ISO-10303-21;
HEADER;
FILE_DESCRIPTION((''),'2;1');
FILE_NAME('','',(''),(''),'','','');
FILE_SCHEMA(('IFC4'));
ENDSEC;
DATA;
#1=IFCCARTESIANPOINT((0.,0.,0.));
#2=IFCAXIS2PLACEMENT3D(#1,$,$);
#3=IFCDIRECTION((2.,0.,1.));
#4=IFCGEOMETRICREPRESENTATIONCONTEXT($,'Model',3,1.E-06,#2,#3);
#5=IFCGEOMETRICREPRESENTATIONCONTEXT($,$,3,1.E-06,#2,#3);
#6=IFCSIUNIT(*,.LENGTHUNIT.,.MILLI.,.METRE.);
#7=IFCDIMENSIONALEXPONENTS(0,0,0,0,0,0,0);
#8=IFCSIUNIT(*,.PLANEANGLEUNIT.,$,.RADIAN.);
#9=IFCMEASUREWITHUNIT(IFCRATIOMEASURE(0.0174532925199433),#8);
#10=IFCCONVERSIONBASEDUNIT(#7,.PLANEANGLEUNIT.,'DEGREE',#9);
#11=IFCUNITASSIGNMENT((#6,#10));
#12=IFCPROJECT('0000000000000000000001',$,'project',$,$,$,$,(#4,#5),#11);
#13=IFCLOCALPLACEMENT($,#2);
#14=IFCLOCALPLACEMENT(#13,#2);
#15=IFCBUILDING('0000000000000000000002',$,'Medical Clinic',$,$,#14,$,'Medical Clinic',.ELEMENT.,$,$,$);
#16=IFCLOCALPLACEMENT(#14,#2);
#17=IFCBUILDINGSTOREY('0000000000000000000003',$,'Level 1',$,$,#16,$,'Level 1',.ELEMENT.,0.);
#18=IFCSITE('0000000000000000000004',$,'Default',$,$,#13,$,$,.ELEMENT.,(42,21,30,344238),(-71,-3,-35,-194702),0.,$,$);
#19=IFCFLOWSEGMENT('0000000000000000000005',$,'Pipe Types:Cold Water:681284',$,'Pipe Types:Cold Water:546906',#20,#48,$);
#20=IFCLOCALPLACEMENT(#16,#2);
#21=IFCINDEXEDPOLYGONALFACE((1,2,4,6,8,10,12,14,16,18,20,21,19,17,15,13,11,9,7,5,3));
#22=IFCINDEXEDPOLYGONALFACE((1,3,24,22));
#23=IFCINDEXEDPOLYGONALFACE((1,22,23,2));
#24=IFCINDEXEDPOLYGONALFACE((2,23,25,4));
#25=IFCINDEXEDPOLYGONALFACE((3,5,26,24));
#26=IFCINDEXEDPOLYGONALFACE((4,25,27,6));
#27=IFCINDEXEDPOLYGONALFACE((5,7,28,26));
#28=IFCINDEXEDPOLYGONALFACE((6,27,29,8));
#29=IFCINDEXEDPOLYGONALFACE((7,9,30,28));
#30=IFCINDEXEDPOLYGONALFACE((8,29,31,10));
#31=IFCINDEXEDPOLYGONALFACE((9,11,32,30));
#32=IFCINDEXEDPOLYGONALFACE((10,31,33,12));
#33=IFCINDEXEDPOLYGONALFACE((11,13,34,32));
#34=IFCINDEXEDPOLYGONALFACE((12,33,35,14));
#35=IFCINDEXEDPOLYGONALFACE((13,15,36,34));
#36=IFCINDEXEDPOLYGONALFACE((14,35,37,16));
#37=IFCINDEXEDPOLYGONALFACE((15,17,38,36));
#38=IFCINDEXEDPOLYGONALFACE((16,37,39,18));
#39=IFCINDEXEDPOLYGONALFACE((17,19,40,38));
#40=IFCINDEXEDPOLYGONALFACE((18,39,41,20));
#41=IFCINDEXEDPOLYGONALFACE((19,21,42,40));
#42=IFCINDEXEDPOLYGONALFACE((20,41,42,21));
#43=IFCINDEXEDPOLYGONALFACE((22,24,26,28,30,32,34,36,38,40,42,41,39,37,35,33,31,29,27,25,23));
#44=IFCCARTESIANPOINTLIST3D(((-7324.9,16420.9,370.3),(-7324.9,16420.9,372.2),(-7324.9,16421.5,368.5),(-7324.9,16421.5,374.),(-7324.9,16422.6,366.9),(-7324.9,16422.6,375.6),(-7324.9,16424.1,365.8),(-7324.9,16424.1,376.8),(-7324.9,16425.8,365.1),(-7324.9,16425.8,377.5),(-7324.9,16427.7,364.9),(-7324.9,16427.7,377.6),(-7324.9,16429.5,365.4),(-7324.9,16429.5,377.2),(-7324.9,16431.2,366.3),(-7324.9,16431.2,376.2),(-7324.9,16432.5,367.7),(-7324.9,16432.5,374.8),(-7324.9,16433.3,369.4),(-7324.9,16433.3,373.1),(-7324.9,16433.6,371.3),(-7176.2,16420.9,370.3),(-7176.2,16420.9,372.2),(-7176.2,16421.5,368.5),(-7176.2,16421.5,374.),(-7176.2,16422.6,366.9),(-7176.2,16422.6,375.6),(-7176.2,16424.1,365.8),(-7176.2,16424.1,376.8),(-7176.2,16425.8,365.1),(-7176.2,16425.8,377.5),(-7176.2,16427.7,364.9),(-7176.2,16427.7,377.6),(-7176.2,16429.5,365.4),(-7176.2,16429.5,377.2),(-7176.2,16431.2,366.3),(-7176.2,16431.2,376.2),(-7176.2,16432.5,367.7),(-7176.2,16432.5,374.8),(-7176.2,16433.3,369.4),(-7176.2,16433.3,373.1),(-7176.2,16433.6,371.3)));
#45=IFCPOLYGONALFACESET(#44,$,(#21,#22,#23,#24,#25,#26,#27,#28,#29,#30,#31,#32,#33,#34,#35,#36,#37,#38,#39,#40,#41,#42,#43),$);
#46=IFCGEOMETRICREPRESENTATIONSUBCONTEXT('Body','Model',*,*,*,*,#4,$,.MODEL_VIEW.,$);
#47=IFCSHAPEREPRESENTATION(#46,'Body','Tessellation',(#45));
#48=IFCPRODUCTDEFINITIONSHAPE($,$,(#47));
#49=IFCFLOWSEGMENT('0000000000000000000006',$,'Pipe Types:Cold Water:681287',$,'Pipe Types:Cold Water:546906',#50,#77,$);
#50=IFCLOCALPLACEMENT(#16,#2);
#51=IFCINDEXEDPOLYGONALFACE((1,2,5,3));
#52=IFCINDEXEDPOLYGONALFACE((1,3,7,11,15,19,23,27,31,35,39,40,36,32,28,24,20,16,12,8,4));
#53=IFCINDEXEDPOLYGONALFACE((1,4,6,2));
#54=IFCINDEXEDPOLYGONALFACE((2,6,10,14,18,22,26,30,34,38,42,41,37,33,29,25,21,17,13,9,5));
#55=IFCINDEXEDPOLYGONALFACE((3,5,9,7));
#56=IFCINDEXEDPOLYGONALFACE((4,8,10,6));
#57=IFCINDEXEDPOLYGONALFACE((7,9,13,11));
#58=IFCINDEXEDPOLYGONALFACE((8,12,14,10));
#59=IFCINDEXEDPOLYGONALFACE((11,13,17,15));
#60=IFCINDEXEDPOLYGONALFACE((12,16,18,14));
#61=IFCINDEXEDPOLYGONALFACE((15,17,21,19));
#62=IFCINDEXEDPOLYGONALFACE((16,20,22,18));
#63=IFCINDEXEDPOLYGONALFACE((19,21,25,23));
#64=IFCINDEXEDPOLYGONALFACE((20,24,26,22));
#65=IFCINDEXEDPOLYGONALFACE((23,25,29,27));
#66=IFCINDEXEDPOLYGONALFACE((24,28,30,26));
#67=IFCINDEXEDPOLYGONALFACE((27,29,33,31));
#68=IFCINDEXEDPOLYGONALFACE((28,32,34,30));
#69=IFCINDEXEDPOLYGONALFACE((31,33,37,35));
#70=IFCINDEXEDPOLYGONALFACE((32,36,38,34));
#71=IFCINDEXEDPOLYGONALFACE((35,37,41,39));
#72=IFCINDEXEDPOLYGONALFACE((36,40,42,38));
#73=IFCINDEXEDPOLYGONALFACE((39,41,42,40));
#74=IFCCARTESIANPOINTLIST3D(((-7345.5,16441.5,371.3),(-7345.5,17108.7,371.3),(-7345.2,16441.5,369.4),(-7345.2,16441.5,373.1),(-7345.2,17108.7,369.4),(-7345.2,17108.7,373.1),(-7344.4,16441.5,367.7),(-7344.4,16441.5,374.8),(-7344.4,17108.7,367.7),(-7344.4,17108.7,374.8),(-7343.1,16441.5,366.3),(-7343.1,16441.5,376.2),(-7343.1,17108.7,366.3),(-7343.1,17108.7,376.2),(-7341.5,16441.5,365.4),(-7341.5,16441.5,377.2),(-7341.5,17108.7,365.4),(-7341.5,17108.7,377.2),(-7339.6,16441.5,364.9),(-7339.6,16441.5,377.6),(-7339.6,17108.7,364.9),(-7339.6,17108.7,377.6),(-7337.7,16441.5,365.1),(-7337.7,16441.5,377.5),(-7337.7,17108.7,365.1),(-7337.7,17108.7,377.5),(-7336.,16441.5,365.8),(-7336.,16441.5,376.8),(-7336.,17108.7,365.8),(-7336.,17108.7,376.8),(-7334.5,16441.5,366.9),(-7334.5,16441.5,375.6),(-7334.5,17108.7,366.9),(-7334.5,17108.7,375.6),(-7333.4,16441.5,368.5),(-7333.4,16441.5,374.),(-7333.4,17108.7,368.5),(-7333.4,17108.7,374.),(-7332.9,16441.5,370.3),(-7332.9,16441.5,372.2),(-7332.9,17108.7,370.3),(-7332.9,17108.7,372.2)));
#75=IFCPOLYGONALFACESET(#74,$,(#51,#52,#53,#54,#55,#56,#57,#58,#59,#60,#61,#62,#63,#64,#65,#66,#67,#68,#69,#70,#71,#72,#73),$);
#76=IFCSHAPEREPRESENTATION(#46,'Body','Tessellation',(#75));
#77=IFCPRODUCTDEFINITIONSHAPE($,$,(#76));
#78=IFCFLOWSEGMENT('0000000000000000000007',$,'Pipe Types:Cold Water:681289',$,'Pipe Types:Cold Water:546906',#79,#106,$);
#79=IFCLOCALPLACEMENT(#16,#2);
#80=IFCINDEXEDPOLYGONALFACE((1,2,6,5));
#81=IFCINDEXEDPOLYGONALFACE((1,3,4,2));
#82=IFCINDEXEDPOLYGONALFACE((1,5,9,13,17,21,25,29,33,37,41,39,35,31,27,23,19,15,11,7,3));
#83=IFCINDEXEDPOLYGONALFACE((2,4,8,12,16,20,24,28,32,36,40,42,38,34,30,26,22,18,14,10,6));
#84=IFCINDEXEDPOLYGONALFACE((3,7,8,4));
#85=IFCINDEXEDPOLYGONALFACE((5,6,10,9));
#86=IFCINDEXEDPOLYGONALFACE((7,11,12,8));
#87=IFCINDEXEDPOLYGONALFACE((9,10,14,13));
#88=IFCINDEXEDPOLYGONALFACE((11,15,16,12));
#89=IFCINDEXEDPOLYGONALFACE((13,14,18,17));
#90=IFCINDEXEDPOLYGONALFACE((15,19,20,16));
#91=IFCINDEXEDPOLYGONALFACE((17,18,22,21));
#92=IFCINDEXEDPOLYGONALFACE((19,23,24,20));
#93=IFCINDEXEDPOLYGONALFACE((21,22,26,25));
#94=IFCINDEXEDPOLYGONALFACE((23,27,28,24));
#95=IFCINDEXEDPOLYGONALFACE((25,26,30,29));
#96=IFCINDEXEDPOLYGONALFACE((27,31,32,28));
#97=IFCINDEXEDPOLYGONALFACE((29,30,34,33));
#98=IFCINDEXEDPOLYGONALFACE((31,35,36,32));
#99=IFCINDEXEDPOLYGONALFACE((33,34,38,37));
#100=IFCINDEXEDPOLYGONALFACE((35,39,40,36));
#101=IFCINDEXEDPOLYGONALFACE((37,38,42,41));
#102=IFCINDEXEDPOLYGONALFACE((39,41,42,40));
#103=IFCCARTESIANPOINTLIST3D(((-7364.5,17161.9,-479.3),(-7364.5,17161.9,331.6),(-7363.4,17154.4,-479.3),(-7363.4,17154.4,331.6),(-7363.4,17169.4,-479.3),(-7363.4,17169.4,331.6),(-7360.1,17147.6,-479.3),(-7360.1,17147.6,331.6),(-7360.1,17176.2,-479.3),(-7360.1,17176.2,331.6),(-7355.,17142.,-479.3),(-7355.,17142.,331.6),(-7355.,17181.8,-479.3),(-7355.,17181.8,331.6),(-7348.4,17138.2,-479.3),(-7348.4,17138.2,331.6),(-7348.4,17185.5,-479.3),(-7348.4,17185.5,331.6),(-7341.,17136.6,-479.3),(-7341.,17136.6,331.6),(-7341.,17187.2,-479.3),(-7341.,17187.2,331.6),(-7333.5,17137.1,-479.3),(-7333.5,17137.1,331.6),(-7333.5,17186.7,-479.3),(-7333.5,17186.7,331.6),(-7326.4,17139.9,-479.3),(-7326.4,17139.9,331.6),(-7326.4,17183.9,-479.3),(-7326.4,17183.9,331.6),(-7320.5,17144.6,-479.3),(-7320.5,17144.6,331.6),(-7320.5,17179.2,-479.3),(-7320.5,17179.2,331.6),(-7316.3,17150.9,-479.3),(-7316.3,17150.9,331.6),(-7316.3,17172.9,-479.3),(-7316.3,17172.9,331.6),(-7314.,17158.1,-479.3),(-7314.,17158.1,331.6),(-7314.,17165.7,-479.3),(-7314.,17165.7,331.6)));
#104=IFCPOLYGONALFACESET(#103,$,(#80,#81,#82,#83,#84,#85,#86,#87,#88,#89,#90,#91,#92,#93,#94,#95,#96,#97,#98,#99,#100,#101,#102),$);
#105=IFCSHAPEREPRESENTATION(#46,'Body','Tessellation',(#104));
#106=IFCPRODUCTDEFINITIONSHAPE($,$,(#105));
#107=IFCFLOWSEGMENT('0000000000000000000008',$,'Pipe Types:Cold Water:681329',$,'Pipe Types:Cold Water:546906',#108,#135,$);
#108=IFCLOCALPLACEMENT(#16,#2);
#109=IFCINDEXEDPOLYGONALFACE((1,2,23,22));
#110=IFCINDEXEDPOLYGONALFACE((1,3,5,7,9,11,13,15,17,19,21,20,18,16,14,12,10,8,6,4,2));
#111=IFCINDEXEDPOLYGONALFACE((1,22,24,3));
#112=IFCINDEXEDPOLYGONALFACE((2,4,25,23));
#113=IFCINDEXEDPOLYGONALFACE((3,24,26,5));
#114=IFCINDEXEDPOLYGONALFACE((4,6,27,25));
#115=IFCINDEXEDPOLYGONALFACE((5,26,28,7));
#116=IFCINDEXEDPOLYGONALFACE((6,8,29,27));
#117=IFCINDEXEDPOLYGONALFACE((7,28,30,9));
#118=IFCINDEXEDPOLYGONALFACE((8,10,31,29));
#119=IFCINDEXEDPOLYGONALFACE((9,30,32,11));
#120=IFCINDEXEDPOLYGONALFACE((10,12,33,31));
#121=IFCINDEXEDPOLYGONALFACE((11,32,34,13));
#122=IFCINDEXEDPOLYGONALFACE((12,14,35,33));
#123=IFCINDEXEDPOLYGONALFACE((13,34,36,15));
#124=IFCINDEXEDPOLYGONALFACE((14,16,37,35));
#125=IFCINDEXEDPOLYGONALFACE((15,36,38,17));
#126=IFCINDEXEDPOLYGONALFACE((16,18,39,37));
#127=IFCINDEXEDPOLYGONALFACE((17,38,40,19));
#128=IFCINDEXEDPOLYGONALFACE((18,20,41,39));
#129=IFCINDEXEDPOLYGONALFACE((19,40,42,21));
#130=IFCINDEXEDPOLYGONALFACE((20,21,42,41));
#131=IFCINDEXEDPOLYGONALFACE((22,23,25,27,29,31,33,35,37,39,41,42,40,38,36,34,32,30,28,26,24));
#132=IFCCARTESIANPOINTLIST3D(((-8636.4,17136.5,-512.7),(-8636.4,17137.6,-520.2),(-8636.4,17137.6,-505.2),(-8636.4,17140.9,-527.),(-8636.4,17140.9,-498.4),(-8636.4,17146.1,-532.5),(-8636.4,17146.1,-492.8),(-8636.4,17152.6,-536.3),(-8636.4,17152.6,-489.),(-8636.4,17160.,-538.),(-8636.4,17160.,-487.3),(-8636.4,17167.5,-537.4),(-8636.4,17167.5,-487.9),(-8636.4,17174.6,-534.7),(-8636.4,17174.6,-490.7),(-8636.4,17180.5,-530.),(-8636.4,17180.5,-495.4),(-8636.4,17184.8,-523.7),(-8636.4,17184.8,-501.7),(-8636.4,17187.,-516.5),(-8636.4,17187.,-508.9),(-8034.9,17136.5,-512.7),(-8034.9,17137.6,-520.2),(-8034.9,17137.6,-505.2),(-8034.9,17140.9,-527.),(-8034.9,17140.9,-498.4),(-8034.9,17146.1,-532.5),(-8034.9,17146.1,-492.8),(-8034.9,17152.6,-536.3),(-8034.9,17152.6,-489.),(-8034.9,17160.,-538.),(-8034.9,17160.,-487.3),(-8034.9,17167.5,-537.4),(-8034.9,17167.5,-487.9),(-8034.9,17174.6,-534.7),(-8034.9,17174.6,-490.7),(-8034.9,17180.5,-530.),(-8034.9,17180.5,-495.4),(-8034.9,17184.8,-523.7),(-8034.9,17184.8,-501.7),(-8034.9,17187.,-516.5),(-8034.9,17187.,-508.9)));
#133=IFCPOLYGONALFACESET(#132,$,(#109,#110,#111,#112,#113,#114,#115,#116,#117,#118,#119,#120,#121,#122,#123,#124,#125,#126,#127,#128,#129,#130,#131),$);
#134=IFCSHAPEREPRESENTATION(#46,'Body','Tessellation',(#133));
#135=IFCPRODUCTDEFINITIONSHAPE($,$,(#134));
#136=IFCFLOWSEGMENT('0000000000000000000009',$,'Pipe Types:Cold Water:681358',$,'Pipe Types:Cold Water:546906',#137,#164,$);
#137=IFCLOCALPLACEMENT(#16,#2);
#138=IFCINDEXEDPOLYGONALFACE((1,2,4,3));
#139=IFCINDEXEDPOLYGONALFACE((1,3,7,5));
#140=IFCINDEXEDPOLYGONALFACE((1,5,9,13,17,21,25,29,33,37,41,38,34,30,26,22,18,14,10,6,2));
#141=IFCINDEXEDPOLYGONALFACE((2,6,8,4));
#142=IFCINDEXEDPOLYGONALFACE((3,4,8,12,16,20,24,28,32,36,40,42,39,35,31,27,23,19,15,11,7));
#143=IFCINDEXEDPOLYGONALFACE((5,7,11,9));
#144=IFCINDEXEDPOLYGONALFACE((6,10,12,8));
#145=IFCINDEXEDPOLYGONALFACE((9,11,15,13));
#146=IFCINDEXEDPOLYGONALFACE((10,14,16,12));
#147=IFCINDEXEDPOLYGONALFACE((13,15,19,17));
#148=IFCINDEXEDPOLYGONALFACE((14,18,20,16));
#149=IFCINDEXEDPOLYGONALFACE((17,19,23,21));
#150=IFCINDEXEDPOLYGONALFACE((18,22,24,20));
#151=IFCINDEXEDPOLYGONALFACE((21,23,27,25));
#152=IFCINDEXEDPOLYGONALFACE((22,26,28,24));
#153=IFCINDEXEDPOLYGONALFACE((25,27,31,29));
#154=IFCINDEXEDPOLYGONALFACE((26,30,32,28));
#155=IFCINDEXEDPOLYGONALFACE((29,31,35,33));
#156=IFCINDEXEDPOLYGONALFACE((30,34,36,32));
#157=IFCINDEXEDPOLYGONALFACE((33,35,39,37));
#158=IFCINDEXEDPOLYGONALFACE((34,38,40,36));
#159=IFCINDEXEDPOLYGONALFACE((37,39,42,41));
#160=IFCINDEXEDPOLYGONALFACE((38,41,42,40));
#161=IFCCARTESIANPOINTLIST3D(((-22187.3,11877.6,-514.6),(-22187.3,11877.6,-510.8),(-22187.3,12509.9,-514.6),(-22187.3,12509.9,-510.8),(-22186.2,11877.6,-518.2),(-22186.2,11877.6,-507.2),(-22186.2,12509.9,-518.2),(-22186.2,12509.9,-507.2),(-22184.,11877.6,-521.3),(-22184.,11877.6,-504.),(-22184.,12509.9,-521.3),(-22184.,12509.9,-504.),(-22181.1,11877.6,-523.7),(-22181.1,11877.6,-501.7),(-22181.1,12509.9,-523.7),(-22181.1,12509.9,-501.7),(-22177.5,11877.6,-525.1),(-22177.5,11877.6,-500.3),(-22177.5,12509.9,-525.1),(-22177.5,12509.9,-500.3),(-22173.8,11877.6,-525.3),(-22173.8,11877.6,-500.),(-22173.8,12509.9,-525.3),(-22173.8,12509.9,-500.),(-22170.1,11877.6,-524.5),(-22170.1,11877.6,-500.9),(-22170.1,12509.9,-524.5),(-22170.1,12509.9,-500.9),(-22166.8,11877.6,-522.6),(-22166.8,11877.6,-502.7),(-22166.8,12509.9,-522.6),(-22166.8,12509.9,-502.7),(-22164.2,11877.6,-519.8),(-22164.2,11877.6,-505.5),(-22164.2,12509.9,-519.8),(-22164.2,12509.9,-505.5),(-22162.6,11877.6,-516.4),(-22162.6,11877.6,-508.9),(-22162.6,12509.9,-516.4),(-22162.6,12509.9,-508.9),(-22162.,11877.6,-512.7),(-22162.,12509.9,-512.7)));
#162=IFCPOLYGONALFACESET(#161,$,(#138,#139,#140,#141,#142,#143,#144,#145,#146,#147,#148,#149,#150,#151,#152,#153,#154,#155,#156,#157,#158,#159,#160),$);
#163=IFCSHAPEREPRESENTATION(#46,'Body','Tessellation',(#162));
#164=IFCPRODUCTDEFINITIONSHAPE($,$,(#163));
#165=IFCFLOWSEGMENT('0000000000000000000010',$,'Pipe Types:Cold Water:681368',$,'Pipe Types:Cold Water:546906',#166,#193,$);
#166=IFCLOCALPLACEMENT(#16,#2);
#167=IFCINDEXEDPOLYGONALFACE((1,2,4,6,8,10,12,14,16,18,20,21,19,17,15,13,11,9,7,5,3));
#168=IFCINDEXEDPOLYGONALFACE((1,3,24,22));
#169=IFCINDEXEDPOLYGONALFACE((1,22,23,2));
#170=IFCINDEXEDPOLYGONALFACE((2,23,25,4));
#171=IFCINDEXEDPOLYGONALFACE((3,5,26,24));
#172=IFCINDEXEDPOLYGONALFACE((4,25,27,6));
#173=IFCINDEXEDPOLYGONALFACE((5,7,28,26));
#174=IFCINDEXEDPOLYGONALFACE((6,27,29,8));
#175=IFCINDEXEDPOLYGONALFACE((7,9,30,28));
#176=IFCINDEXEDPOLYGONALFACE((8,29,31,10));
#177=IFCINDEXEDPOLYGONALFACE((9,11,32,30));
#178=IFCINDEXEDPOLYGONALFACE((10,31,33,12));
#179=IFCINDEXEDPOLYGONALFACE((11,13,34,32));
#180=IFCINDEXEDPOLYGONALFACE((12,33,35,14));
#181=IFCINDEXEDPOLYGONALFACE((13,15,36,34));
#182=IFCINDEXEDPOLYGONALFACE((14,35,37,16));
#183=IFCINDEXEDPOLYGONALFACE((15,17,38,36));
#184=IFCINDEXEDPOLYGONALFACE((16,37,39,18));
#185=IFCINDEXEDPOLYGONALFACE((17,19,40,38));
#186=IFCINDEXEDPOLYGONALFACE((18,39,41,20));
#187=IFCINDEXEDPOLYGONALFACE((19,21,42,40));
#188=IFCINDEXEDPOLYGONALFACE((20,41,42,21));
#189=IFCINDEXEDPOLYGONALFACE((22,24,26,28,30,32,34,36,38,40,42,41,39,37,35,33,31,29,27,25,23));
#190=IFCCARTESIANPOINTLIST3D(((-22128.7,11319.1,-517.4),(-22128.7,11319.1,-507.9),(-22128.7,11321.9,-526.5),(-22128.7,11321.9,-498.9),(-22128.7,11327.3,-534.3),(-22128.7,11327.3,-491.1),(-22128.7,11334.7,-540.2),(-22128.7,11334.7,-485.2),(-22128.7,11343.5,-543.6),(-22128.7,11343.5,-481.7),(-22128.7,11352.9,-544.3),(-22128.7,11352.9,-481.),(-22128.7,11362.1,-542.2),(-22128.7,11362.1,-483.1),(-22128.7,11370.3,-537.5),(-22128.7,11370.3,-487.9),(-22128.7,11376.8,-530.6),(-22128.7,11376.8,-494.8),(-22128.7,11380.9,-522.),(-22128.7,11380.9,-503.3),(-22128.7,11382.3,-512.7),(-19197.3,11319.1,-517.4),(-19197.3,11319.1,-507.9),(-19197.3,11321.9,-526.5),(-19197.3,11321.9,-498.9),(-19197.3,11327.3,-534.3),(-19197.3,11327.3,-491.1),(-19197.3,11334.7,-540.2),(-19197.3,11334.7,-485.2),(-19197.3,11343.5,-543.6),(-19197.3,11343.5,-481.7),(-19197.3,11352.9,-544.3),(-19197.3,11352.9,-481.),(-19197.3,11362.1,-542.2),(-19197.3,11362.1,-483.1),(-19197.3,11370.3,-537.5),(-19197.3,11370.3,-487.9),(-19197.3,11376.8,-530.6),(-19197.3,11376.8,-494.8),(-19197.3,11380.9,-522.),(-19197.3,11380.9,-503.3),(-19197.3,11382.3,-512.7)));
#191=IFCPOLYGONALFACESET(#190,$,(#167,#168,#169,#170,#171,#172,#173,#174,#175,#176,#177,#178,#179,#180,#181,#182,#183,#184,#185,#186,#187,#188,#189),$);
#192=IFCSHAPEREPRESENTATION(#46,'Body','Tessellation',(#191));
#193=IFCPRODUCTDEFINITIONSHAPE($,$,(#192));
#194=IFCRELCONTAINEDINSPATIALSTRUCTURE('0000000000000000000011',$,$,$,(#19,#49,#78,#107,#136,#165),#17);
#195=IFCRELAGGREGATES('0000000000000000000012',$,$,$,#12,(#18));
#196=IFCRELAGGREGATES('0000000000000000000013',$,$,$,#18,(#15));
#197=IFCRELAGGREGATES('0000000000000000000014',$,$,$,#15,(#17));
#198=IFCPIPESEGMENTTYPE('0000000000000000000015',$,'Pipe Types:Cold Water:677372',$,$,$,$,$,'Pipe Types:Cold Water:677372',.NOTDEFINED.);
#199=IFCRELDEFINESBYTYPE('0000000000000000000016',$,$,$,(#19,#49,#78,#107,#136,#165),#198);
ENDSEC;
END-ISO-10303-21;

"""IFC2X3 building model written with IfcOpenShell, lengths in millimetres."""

from ifc_helpers import new_model, entity, si_unit, converted_unit, direction, frame, frame_2d, origin, origin_2d_with_axis, place, context, subcontext, project, spatial, circle, extrude, type_object, element, save


model = new_model("IFC2X3")

# Units and contexts
model_context = context("Model", 3, precision=1e-06, world=origin(), true_north=direction((2.0, 0.0, 1.0)))
context_of_model = context(None, 3, precision=1e-06, world=origin(), true_north=direction((2.0, 0.0, 1.0)))
body_context = subcontext(model_context, "Body", "Model", "MODEL_VIEW")
ifc_project = project(units=[si_unit("LENGTHUNIT", "METRE", prefix="MILLI"), converted_unit("PLANEANGLEUNIT", "DEGREE", entity("IfcRatioMeasure", 0.0174532925199433), si_unit("PLANEANGLEUNIT", "RADIAN"), dimensions=[0, 0, 0, 0, 0, 0, 0])], contexts=[model_context, context_of_model])

# Site, building, storey
site_placement = place(None, origin())
site = spatial("IfcSite", under=ifc_project, at=site_placement, Name="Default", CompositionType="ELEMENT", RefLatitude=(42, 21, 30, 344238), RefLongitude=(-71, -3, -35, -194702), RefElevation=0.0)
building_placement = place(site_placement, origin())
building = spatial("IfcBuilding", under=site, at=building_placement, Name="Medical Clinic", LongName="Medical Clinic", CompositionType="ELEMENT")
storey_placement = place(building_placement, origin())
storey = spatial("IfcBuildingStorey", under=building, at=storey_placement, Name="Level 1", LongName="Level 1", CompositionType="ELEMENT", Elevation=0.0)

# Flow segments
pipe_segment_type_1 = type_object("IfcPipeSegmentType", Name="Pipe Types:Cold Water:677372", ElementType="Pipe Types:Cold Water:677372", PredefinedType="NOTDEFINED")
flow_segment_1_placement = place(storey_placement, origin())
element("IfcFlowSegment", 1, at=flow_segment_1_placement, inside=storey, type_object=pipe_segment_type_1, Name="Pipe Types:Cold Water:681284", ObjectType="Pipe Types:Cold Water:546906", context=body_context, shape_type="SweptSolid", body=[
    extrude(circle(Radius=6.3, at=frame_2d((0.0, 0.0), x_axis=(1.0, 0.0))), frame((-7324.9, 16427.2, 371.3), z_axis=(1.0, 0.0, 0.0), x_axis=(0.0, 1.0, 0.0)), (0.0, 0.0, 1.0), 148.7),
])
flow_segment_2_placement = place(storey_placement, origin())
element("IfcFlowSegment", 2, at=flow_segment_2_placement, inside=storey, type_object=pipe_segment_type_1, Name="Pipe Types:Cold Water:681287", ObjectType="Pipe Types:Cold Water:546906", context=body_context, shape_type="SweptSolid", body=[
    extrude(circle(Radius=6.3, at=origin_2d_with_axis()), frame((-7339.1, 16441.5, 371.3), z_axis=(0.0, 1.0, 0.0), x_axis=(-1.0, 0.0, 0.0)), (0.0, 0.0, 1.0), 667.2),
])
flow_segment_3_placement = place(storey_placement, origin())
element("IfcFlowSegment", 3, at=flow_segment_3_placement, inside=storey, type_object=pipe_segment_type_1, Name="Pipe Types:Cold Water:681289", ObjectType="Pipe Types:Cold Water:546906", context=body_context, shape_type="SweptSolid", body=[
    extrude(circle(Radius=25.4, at=origin_2d_with_axis()), frame((-7339.1, 17161.9, -479.3), z_axis=(0.0, 0.0, 1.0), x_axis=(-1.0, 0.0, 0.0)), (0.0, 0.0, 1.0), 810.9),
])
flow_segment_4_placement = place(storey_placement, origin())
element("IfcFlowSegment", 4, at=flow_segment_4_placement, inside=storey, type_object=pipe_segment_type_1, Name="Pipe Types:Cold Water:681329", ObjectType="Pipe Types:Cold Water:546906", context=body_context, shape_type="SweptSolid", body=[
    extrude(circle(Radius=25.4, at=frame_2d((0.0, 0.0), x_axis=(1.0, 0.0))), frame((-8636.4, 17161.9, -512.7), z_axis=(1.0, 0.0, 0.0), x_axis=(0.0, -1.0, 0.0)), (0.0, 0.0, 1.0), 601.5),
])
flow_segment_5_placement = place(storey_placement, origin())
element("IfcFlowSegment", 5, at=flow_segment_5_placement, inside=storey, type_object=pipe_segment_type_1, Name="Pipe Types:Cold Water:681358", ObjectType="Pipe Types:Cold Water:546906", context=body_context, shape_type="SweptSolid", body=[
    extrude(circle(Radius=12.7, at=origin_2d_with_axis()), frame((-22174.7, 11877.6, -512.7), z_axis=(0.0, 1.0, 0.0), x_axis=(1.0, 0.0, 0.0)), (0.0, 0.0, 1.0), 632.2),
])
flow_segment_6_placement = place(storey_placement, origin())
element("IfcFlowSegment", 6, at=flow_segment_6_placement, inside=storey, type_object=pipe_segment_type_1, Name="Pipe Types:Cold Water:681368", ObjectType="Pipe Types:Cold Water:546906", context=body_context, shape_type="SweptSolid", body=[
    extrude(circle(Radius=31.8, at=frame_2d((0.0, 0.0), x_axis=(1.0, 0.0))), frame((-22128.7, 11350.5, -512.7), z_axis=(1.0, 0.0, 0.0), x_axis=(0.0, 1.0, 0.0)), (0.0, 0.0, 1.0), 2931.4),
])

save(model, "model.ifc")
